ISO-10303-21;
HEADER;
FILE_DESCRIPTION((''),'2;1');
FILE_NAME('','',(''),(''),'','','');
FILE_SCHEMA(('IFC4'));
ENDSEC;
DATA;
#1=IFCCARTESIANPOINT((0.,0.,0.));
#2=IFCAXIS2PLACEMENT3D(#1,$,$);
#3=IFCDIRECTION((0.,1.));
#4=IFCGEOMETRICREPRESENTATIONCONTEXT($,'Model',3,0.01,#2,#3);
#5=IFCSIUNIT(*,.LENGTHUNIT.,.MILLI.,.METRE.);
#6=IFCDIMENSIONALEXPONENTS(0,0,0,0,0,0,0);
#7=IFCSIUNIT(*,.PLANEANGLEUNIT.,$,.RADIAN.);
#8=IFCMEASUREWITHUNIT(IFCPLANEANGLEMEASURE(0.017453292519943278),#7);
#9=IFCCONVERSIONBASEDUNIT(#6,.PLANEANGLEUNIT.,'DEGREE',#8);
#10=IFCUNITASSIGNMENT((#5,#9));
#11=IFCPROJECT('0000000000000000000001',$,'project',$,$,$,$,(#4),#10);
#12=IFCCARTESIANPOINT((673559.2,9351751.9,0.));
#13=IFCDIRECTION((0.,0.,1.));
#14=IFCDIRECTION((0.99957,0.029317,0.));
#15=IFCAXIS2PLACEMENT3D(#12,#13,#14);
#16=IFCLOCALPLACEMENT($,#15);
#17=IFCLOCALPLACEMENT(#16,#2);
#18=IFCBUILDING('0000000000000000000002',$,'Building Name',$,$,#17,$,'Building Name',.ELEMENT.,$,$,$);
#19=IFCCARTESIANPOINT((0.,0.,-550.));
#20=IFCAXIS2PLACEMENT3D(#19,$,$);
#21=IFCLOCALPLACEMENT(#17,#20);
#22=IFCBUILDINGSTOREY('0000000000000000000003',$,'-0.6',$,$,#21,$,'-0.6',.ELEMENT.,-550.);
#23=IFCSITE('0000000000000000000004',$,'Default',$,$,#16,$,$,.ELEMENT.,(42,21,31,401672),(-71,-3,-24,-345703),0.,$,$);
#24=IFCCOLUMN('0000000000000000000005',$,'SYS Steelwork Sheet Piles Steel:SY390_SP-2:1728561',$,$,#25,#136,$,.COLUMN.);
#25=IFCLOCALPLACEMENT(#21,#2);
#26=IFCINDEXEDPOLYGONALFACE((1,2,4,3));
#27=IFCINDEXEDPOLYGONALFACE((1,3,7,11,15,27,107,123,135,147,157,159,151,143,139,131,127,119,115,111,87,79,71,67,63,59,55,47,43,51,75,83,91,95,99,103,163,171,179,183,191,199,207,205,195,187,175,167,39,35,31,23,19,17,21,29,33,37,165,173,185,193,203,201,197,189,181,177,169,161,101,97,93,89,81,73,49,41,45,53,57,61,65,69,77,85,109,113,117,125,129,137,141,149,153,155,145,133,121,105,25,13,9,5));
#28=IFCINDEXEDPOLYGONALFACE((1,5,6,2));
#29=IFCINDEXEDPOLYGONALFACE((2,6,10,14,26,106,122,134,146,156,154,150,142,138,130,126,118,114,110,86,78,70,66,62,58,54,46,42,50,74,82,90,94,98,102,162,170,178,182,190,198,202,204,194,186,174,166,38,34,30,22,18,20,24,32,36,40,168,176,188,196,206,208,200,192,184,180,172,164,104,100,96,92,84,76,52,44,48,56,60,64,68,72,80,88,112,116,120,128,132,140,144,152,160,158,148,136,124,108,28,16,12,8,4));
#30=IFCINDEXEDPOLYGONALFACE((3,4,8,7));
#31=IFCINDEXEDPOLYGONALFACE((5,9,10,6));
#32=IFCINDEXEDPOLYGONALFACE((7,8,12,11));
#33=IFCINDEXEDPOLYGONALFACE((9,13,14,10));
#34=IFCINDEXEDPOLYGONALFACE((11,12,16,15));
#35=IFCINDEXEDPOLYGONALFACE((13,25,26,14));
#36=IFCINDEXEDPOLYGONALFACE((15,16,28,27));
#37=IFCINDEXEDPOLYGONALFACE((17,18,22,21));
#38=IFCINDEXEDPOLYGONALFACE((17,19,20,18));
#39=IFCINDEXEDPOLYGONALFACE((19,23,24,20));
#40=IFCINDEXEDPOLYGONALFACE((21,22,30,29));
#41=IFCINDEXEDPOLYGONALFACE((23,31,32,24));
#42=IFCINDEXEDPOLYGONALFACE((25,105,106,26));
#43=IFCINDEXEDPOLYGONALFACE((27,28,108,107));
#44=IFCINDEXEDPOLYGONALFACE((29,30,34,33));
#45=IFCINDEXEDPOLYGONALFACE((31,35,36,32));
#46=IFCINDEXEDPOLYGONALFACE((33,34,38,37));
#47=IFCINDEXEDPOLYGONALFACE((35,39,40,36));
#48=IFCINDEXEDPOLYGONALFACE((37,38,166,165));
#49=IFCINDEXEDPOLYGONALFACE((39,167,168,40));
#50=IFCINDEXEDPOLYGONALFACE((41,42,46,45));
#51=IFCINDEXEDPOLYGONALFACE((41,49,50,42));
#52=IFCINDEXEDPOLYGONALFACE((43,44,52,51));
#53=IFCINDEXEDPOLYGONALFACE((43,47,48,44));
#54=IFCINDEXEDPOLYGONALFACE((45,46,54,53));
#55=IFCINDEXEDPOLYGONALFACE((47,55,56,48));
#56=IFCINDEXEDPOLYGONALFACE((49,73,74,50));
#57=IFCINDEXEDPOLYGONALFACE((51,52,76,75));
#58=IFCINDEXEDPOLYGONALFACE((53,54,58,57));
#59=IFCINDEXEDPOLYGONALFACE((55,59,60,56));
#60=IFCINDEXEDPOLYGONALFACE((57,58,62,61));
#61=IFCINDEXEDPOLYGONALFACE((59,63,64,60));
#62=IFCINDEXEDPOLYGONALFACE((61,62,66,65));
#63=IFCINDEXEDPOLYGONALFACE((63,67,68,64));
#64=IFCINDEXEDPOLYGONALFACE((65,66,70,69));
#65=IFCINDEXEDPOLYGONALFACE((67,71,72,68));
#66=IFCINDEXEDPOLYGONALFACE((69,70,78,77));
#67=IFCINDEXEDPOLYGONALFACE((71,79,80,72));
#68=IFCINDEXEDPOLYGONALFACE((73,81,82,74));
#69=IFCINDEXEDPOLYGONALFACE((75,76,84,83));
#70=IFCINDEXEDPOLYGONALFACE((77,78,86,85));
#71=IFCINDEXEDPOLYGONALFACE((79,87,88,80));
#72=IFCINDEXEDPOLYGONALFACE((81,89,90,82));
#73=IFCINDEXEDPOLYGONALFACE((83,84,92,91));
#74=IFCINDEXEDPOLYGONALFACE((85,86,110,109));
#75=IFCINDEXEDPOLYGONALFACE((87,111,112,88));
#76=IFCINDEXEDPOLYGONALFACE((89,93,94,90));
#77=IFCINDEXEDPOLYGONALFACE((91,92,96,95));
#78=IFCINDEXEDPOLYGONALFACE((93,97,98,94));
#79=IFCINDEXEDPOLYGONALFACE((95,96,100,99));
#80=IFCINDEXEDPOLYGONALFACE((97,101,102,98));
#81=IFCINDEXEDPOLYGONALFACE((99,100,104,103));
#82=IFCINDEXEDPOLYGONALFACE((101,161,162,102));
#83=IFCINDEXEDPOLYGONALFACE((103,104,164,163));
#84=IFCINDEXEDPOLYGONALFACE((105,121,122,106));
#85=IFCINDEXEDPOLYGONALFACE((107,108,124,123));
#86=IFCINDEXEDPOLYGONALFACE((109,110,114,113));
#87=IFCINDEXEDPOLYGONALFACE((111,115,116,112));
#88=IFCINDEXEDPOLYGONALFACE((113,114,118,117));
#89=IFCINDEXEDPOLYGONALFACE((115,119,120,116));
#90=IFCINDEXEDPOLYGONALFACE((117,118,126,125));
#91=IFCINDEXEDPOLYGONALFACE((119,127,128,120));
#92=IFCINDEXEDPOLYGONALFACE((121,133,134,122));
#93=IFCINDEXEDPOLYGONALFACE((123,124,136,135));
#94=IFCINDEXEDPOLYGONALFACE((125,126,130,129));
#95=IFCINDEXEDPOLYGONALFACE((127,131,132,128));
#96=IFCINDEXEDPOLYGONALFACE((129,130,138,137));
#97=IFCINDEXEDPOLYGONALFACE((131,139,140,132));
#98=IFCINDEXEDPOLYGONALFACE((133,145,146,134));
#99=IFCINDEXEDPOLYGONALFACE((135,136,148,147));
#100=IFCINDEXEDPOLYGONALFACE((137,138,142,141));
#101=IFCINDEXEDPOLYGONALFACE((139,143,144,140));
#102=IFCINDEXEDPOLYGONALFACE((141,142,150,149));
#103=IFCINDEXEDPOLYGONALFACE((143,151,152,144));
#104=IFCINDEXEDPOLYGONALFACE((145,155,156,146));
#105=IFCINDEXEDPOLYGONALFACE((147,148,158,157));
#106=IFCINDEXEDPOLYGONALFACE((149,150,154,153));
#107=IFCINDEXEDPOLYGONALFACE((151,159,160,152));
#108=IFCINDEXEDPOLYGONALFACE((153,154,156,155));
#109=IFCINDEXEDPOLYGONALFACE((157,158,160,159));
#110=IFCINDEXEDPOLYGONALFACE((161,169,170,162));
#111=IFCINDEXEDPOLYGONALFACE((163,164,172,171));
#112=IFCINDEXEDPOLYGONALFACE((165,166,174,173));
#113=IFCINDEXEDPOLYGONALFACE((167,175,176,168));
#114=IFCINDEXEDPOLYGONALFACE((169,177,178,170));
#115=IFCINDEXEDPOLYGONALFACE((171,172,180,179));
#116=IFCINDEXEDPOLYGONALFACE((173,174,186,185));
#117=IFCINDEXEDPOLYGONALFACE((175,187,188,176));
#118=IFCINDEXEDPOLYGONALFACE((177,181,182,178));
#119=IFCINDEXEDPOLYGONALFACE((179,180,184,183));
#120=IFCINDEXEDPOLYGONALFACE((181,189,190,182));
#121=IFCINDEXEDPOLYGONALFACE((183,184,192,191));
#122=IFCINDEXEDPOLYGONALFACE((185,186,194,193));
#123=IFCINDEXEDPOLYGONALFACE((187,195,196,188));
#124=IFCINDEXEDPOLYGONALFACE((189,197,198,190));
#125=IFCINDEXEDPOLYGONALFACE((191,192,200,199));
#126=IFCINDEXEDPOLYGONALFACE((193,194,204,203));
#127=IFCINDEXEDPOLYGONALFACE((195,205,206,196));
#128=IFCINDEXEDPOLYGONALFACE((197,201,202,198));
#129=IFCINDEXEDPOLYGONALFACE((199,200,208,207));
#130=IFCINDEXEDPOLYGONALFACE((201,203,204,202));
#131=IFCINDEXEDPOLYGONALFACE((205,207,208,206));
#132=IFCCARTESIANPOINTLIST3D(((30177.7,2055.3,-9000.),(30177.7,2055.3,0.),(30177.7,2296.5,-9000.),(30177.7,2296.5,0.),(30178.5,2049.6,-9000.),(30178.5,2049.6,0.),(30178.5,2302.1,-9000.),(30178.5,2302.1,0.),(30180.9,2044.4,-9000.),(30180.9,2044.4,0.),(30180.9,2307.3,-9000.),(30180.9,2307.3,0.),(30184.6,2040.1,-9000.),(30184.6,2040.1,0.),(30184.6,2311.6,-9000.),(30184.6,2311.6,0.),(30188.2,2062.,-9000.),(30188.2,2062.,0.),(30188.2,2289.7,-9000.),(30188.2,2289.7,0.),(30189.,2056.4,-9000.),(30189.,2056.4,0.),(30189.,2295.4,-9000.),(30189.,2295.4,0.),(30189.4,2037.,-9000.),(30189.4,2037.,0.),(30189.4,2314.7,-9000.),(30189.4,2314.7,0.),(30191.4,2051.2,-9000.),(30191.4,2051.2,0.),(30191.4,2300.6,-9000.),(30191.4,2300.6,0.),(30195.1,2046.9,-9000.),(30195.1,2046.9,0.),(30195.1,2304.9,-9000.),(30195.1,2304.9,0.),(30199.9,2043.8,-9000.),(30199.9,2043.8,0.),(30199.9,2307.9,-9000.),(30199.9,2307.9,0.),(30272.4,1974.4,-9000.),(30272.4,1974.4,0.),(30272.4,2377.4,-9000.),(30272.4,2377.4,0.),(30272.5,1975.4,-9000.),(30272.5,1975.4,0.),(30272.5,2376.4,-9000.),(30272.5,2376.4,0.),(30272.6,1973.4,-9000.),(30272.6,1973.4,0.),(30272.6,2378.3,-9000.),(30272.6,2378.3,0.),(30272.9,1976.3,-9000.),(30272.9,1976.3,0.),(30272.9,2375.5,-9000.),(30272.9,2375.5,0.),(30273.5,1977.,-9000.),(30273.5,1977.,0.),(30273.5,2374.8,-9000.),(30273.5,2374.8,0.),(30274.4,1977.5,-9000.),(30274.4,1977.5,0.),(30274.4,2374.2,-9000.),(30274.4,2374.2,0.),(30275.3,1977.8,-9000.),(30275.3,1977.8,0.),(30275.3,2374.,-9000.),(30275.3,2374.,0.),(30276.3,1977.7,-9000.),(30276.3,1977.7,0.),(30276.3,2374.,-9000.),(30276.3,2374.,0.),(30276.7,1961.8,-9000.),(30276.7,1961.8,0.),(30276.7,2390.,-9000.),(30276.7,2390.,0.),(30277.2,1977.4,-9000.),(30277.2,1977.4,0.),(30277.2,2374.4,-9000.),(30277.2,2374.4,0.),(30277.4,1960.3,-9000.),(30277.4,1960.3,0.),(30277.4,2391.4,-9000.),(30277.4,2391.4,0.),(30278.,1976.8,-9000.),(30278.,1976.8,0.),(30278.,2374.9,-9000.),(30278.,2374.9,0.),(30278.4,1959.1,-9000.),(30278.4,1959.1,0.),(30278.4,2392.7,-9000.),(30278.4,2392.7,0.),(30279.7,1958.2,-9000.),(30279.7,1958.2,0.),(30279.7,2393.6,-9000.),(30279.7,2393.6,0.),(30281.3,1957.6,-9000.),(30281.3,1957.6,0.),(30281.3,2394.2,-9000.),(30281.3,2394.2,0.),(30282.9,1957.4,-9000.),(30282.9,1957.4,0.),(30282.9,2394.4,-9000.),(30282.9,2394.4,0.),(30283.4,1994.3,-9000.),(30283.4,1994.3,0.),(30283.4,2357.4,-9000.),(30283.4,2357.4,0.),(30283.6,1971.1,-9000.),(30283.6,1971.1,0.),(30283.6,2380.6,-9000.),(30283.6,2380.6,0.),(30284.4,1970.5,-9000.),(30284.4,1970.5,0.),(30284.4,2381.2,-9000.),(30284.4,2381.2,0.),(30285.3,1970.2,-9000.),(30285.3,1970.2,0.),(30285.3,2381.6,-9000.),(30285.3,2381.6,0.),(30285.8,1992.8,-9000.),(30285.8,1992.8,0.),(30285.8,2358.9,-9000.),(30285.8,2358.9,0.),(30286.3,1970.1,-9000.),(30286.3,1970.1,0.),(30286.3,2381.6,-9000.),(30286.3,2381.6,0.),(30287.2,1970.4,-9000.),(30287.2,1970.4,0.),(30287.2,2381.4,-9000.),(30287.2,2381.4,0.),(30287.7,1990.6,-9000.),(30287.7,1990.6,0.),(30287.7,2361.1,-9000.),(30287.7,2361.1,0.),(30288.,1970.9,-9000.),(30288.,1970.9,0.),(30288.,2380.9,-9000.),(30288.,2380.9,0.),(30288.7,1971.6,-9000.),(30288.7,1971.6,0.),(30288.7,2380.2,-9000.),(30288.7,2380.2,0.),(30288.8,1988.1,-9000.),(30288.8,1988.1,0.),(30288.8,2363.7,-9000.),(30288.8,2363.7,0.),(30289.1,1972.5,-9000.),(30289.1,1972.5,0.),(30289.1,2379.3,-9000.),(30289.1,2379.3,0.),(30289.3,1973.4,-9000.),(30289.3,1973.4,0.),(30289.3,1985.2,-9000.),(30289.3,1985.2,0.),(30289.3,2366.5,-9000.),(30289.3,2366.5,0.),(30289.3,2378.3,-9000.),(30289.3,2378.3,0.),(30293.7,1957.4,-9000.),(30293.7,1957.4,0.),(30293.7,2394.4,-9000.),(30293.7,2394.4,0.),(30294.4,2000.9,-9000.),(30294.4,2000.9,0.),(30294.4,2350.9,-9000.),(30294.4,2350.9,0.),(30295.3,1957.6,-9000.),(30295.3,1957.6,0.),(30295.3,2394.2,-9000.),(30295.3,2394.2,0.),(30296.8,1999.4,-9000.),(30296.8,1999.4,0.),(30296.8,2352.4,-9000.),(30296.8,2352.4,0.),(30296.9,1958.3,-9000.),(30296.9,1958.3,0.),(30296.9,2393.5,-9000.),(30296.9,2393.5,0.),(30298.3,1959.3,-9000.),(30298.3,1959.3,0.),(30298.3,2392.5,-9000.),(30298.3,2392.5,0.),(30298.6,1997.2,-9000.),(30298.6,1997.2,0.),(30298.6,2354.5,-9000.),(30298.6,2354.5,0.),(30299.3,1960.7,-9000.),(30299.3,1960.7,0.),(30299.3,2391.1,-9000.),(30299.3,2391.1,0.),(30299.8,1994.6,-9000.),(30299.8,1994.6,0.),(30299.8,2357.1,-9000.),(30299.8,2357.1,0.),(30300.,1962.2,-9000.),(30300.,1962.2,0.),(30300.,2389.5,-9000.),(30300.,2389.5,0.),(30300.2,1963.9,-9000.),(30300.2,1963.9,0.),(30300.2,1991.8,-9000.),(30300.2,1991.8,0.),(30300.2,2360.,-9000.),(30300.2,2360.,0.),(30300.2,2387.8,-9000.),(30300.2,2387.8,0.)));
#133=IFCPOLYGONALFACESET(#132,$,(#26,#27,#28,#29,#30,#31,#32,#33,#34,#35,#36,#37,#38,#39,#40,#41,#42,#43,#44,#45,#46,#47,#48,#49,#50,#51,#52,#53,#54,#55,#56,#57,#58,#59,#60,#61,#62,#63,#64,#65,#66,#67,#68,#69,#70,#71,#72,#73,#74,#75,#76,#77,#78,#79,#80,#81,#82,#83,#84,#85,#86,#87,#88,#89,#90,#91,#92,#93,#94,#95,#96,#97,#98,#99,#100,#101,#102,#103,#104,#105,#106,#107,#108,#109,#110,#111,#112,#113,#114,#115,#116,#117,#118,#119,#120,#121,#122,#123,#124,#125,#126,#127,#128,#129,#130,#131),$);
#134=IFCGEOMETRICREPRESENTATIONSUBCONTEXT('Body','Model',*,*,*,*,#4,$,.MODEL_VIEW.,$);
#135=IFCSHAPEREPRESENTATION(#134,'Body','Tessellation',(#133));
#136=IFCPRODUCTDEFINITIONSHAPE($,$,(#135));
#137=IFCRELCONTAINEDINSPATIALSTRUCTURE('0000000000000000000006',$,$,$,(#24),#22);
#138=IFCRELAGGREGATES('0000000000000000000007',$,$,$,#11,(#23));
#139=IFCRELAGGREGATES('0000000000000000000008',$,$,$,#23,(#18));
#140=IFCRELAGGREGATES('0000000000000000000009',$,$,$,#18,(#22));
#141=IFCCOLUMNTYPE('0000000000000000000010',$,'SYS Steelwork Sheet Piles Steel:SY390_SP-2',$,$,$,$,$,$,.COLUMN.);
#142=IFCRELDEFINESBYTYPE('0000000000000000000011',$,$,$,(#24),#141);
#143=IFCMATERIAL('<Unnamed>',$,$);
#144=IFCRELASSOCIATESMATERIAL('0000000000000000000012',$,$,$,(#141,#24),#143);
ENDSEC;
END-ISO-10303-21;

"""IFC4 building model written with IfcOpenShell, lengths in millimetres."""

from ifc_helpers import new_model, entity, si_unit, converted_unit, direction, frame, origin, place, context, subcontext, project, spatial, line, arc, indexed_curve, outline, extrude, source, transform, mapped, material, type_object, type_shapes, element, save


model = new_model("IFC4")

# Units and contexts
model_context = context("Model", 3, precision=0.01, world=origin(), true_north=direction((0.0, 1.0)))
body_context = subcontext(model_context, "Body", "Model", "MODEL_VIEW")
ifc_project = project(units=[si_unit("LENGTHUNIT", "METRE", prefix="MILLI"), converted_unit("PLANEANGLEUNIT", "DEGREE", entity("IfcPlaneAngleMeasure", 0.017453292519943278), si_unit("PLANEANGLEUNIT", "RADIAN"), dimensions=[0, 0, 0, 0, 0, 0, 0])], contexts=[model_context])

# Site, building, storey
site_placement = place(None, frame((673559.2, 9351751.9, 0.0), z_axis=(0.0, 0.0, 1.0), x_axis=(0.99957, 0.029317, 0.0)))
site = spatial("IfcSite", under=ifc_project, at=site_placement, Name="Default", CompositionType="ELEMENT", RefLatitude=(42, 21, 31, 401672), RefLongitude=(-71, -3, -24, -345703), RefElevation=0.0)
building_placement = place(site_placement, origin())
building = spatial("IfcBuilding", under=site, at=building_placement, Name="Building Name", LongName="Building Name", CompositionType="ELEMENT")
storey_placement = place(building_placement, frame((0.0, 0.0, -550.0)))
storey = spatial("IfcBuildingStorey", under=building, at=storey_placement, Name="-0.6", LongName="-0.6", CompositionType="ELEMENT", Elevation=-550.0)

# Column
ifc_material_1 = material(Name="<Unnamed>")
column_type = type_object("IfcColumnType", Name="SYS Steelwork Sheet Piles Steel:SY390_SP-2", PredefinedType="COLUMN", material=ifc_material_1)
shared_shape_1 = source(origin(), body_context, "Body", "SweptSolid", [
    extrude(outline(indexed_curve([(-120.6, 84.7), (-131.4, 81.6), (-138.8, 73.0), (-181.5, -20.9), (-185.2, -25.2), (-190.6, -26.8), (-202.5, -26.8), (-205.5, -24.8), (-204.8, -21.2), (-199.1, -15.5), (-198.6, -11.5), (-202.5, -10.1), (-214.1, -14.2), (-217.3, -16.6), (-218.5, -20.4), (-218.5, -31.2), (-216.6, -35.8), (-211.9, -37.8), (-184.1, -37.8), (-178.7, -36.2), (-175.0, -31.9), (-132.1, 62.5), (-124.7, 71.1), (-113.9, 74.2), (113.9, 74.2), (124.7, 71.1), (132.1, 62.5), (175.0, -31.9), (178.7, -36.2), (184.1, -37.8), (211.9, -37.8), (216.6, -35.8), (218.5, -31.2), (218.5, -20.4), (217.3, -16.6), (214.1, -14.2), (202.5, -10.1), (198.6, -11.5), (199.1, -15.5), (204.8, -21.2), (205.5, -24.8), (202.5, -26.8), (190.6, -26.8), (185.2, -25.2), (181.5, -20.9), (138.8, 73.0), (131.4, 81.6), (120.6, 84.7)], segments=[arc(1, 2, 3), line(3, 4), arc(4, 5, 6), line(6, 7), arc(7, 8, 9), line(9, 10), arc(10, 11, 12), line(12, 13), arc(13, 14, 15), line(15, 16), arc(16, 17, 18), line(18, 19), arc(19, 20, 21), line(21, 22), arc(22, 23, 24), line(24, 25), arc(25, 26, 27), line(27, 28), arc(28, 29, 30), line(30, 31), arc(31, 32, 33), line(33, 34), arc(34, 35, 36), line(36, 37), arc(37, 38, 39), line(39, 40), arc(40, 41, 42), line(42, 43), arc(43, 44, 45), line(45, 46), arc(46, 47, 48), line(48, 1)], self_intersect=False)), frame((0.0, 15.3, -9550.0)), (0.0, 0.0, 1.0), 9000.0),
])
type_shapes(column_type, [shared_shape_1])
for number, where, z_axis, x_axis, name in (
    (1, (30277.7, 2175.9, 550.0), (0.0, 0.0, 1.0), (0.0, 1.0, 0.0), "SYS Steelwork Sheet Piles Steel:SY390_SP-2:1728561"),
):
    element("IfcColumn", number, at=place(storey_placement, frame(where, z_axis=z_axis, x_axis=x_axis)), inside=storey, type_object=column_type, material=ifc_material_1, Name=name, PredefinedType="COLUMN", context=body_context, shape_type="MappedRepresentation", body=[
        mapped(shared_shape_1, transform((0.0, 0.0, 0.0), scale=1.0)),
    ])

save(model, "model.ifc")
